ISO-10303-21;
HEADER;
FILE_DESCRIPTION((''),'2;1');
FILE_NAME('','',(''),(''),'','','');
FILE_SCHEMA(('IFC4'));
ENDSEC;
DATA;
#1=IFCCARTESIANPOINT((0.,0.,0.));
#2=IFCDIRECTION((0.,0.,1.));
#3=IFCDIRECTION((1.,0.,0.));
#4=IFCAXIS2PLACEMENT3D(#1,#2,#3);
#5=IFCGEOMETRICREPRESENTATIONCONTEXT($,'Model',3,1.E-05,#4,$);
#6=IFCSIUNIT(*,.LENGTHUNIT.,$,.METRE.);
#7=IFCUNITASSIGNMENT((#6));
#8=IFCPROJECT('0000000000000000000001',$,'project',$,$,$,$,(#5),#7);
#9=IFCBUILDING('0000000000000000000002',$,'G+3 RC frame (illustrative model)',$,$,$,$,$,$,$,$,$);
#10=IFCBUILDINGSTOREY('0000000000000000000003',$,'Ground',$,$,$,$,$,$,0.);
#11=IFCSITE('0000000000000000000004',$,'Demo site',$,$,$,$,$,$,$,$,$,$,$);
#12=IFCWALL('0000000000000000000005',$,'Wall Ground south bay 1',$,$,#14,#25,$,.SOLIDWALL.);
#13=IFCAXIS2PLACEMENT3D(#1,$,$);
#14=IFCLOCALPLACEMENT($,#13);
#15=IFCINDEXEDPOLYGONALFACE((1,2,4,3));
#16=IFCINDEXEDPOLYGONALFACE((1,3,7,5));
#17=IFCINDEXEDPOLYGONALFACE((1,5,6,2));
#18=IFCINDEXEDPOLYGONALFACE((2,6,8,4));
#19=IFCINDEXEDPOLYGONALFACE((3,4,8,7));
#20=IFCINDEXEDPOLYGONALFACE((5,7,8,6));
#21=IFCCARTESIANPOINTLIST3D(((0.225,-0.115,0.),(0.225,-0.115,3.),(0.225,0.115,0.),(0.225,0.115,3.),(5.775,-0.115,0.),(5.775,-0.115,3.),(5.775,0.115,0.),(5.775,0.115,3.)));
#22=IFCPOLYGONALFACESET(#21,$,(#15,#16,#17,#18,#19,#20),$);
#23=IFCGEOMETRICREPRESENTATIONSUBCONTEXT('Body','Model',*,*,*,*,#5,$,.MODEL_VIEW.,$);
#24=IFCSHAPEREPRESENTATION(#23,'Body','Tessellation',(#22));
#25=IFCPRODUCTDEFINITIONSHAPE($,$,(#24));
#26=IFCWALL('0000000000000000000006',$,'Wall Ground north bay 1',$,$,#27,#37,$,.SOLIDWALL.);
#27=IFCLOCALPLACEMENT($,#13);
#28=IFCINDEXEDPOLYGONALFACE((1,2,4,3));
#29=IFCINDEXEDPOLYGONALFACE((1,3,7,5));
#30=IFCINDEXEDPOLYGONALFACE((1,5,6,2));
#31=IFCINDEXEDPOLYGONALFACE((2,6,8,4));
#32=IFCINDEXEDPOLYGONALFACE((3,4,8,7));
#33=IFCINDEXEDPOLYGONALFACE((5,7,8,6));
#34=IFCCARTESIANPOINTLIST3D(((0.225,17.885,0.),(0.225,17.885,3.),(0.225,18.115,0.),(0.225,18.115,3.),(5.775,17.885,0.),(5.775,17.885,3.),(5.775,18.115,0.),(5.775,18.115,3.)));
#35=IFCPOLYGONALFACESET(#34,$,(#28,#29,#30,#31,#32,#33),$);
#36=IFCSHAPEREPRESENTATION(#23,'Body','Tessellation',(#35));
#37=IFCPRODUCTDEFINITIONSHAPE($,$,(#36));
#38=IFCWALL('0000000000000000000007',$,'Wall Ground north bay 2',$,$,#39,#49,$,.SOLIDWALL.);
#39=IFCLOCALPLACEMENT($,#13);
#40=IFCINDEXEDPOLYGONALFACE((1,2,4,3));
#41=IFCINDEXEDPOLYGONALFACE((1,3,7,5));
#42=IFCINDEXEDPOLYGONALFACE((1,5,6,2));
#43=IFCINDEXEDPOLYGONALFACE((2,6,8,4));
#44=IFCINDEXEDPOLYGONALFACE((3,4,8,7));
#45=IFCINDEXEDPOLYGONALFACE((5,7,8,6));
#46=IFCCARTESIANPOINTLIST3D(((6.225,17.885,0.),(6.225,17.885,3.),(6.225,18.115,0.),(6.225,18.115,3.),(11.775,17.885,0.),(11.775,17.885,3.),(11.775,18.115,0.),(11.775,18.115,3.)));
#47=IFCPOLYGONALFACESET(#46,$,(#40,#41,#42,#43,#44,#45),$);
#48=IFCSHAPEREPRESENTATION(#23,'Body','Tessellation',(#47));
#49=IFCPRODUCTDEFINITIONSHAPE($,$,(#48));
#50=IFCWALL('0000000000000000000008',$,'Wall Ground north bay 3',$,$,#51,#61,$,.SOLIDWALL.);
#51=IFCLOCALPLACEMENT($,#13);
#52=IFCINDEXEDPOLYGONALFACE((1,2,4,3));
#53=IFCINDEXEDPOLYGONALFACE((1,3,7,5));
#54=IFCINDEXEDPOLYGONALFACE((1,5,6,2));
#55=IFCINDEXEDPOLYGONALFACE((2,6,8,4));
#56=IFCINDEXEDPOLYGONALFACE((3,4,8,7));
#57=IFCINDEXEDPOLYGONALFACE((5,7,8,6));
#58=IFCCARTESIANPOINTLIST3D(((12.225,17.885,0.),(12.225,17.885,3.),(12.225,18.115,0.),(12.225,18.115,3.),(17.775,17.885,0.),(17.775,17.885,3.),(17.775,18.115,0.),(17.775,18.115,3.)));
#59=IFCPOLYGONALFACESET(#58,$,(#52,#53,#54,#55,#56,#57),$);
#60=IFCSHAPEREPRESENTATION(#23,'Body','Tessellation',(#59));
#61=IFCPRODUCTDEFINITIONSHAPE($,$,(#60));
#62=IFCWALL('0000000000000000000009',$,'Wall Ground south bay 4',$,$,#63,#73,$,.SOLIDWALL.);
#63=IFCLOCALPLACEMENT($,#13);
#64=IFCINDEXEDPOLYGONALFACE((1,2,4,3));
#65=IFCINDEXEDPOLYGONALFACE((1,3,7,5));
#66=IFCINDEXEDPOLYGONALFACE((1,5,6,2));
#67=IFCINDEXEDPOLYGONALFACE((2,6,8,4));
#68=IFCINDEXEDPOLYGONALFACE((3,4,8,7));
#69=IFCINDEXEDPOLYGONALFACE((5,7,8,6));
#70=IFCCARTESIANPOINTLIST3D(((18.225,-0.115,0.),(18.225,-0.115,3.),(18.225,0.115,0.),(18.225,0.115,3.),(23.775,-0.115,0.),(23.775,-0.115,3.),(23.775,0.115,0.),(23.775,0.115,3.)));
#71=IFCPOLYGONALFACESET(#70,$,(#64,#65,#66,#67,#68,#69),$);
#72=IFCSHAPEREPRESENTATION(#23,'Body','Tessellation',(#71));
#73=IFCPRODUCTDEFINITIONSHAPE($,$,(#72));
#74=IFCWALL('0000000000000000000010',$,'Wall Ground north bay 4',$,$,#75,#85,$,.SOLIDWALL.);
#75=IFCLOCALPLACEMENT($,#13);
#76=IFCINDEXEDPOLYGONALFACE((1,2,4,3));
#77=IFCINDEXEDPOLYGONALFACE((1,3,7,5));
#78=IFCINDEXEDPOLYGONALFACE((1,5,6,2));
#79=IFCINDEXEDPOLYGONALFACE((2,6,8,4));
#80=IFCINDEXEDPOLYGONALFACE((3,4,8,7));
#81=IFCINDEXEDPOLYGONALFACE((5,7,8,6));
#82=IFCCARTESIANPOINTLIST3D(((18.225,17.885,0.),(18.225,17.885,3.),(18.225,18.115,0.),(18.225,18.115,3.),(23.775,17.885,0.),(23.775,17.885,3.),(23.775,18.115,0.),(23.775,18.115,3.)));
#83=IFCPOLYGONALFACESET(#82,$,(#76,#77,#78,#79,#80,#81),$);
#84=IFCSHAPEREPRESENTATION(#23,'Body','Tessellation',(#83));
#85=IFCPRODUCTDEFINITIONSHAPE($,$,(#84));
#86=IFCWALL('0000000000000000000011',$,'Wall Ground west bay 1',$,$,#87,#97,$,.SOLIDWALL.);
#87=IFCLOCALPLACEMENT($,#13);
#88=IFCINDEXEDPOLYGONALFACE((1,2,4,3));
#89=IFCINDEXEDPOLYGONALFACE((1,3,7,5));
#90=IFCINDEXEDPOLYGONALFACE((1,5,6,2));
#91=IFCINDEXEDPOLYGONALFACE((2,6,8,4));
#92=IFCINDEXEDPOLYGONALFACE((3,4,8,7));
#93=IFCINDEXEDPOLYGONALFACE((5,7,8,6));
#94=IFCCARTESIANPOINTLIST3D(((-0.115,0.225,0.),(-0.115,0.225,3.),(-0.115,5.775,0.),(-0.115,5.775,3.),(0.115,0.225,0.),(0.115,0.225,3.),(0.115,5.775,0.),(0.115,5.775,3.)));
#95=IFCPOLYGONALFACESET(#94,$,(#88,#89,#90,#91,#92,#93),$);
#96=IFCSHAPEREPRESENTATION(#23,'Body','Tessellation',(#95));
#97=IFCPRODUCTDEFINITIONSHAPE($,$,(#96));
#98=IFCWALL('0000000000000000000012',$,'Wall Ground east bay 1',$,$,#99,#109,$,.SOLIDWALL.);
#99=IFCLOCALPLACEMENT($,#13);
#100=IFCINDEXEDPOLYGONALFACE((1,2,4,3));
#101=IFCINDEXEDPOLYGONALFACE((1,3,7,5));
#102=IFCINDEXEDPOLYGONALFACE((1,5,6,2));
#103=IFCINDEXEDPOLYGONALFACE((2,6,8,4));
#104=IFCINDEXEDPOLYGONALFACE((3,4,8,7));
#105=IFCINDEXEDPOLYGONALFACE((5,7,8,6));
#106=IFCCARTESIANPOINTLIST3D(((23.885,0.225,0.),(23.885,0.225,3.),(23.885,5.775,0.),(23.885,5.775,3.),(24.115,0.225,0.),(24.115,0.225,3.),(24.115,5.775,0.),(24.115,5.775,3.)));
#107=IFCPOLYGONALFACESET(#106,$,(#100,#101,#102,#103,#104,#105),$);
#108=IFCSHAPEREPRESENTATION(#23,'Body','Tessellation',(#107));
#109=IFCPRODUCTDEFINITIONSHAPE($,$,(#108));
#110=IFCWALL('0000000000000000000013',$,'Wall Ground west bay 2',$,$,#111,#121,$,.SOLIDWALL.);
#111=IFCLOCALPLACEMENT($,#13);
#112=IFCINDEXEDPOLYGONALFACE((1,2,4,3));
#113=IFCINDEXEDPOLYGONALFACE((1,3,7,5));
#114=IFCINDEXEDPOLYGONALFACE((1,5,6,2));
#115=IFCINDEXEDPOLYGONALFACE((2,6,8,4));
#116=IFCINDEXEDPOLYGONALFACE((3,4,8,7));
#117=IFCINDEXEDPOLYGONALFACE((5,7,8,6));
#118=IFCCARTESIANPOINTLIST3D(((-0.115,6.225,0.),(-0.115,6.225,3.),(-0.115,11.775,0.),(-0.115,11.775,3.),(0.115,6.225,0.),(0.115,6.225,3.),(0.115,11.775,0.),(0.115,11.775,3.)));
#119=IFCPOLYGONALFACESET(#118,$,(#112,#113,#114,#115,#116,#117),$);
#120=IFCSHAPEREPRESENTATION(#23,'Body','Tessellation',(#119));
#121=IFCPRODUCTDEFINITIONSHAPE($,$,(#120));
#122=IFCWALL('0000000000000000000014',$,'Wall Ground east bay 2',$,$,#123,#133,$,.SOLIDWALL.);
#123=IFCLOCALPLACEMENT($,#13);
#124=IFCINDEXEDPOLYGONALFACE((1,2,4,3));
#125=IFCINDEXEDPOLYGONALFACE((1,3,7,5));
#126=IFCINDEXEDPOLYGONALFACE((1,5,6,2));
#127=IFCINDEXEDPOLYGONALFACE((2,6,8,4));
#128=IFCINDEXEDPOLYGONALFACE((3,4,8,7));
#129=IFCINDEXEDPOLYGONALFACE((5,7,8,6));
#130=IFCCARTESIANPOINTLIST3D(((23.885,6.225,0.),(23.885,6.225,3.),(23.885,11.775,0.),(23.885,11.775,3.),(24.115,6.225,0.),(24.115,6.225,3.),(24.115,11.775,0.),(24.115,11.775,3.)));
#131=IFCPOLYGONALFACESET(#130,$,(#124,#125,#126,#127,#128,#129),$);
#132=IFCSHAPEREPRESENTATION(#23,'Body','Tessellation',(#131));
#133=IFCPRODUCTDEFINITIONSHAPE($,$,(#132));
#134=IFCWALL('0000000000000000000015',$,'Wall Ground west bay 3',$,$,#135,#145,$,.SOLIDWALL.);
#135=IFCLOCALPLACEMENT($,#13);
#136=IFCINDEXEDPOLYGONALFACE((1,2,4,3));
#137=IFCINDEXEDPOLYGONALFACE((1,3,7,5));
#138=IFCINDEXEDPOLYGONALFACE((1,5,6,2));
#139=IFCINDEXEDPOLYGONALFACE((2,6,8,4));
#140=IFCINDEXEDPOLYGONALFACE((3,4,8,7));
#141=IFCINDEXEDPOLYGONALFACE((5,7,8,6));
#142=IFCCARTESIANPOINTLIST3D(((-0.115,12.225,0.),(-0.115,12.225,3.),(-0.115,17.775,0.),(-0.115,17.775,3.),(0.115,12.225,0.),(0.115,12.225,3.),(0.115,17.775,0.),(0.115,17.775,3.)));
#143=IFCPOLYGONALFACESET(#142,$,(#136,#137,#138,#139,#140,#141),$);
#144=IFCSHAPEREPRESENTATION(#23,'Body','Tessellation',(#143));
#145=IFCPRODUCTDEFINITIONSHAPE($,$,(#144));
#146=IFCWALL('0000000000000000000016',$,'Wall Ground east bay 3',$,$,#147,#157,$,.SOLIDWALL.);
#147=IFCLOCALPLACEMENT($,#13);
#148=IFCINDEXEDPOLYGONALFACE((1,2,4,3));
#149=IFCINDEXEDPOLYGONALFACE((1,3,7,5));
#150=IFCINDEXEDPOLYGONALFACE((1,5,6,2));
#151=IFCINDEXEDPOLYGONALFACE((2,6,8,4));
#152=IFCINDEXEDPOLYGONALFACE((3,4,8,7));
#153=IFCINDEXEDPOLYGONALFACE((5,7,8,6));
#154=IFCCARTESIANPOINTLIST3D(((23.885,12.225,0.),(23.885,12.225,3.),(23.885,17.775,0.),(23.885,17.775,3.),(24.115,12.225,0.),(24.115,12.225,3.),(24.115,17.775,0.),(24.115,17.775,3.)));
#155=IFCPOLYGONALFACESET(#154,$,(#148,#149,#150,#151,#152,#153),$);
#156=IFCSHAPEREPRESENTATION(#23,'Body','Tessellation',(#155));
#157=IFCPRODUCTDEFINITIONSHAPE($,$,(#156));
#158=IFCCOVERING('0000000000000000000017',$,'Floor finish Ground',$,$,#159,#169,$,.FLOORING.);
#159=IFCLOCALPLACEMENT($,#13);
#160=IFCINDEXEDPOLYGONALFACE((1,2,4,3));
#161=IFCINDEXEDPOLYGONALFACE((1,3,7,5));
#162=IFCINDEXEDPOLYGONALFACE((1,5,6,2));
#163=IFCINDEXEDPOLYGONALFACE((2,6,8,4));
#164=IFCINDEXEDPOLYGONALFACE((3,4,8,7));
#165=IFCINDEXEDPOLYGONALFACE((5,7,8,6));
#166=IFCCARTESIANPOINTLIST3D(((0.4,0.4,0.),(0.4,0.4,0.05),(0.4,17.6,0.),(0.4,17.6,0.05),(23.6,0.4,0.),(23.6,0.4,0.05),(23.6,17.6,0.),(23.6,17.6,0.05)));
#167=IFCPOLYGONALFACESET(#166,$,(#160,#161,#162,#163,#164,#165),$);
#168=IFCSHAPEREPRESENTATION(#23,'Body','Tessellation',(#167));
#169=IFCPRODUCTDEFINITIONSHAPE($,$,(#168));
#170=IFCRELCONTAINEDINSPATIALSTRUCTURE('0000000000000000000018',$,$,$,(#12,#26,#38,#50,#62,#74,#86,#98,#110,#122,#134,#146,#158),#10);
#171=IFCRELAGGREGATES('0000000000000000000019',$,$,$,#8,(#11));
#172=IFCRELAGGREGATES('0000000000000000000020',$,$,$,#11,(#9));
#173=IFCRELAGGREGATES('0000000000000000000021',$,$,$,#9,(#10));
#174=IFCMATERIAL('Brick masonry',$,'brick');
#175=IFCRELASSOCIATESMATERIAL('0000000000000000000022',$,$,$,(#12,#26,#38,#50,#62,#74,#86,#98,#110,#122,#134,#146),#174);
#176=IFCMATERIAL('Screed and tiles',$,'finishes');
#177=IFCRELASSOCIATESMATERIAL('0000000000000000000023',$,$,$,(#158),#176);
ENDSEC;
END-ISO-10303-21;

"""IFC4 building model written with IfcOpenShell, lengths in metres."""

from ifc_helpers import new_model, si_unit, frame, frame_2d, origin, origin_with_axes, place, context, subcontext, project, spatial, rectangle, extrude, material, element, save


model = new_model("IFC4")

# Units and contexts
model_context = context("Model", 3, precision=1e-05, world=origin_with_axes())
body_context = subcontext(model_context, "Body", "Model", "MODEL_VIEW")
ifc_project = project(units=[si_unit("LENGTHUNIT", "METRE")], contexts=[model_context])

# Site, building, storey
site = spatial("IfcSite", under=ifc_project, Name="Demo site")
building = spatial("IfcBuilding", under=site, Name="G+3 RC frame (illustrative model)")
storey = spatial("IfcBuildingStorey", under=building, Name="Ground", Elevation=0.0)

# Walls
ifc_material_1 = material(Name="Brick masonry", Category="brick")
for number, where, z_axis, x_axis, name in (
    (1, (0.225, -0.115, 0.0), (0.0, 0.0, 1.0), (1.0, 0.0, 0.0), "Wall Ground south bay 1"),
    (2, (0.225, 17.885, 0.0), (0.0, 0.0, 1.0), (1.0, 0.0, 0.0), "Wall Ground north bay 1"),
    (3, (6.225, 17.885, 0.0), (0.0, 0.0, 1.0), (1.0, 0.0, 0.0), "Wall Ground north bay 2"),
    (4, (12.225, 17.885, 0.0), (0.0, 0.0, 1.0), (1.0, 0.0, 0.0), "Wall Ground north bay 3"),
    (5, (18.225, -0.115, 0.0), (0.0, 0.0, 1.0), (1.0, 0.0, 0.0), "Wall Ground south bay 4"),
    (6, (18.225, 17.885, 0.0), (0.0, 0.0, 1.0), (1.0, 0.0, 0.0), "Wall Ground north bay 4"),
):
    element("IfcWall", number, at=place(None, frame(where, z_axis=z_axis, x_axis=x_axis)), inside=storey, material=ifc_material_1, Name=name, PredefinedType="SOLIDWALL", context=body_context, shape_type="SweptSolid", body=[
        extrude(rectangle(XDim=5.55, YDim=0.23, at=frame_2d((2.775, 0.115))), origin(), (0.0, 0.0, 1.0), 3.0),
    ])
for number, where, z_axis, x_axis, name in (
    (7, (-0.115, 0.225, 0.0), (0.0, 0.0, 1.0), (1.0, 0.0, 0.0), "Wall Ground west bay 1"),
    (8, (23.885, 0.225, 0.0), (0.0, 0.0, 1.0), (1.0, 0.0, 0.0), "Wall Ground east bay 1"),
    (9, (-0.115, 6.225, 0.0), (0.0, 0.0, 1.0), (1.0, 0.0, 0.0), "Wall Ground west bay 2"),
    (10, (23.885, 6.225, 0.0), (0.0, 0.0, 1.0), (1.0, 0.0, 0.0), "Wall Ground east bay 2"),
    (11, (-0.115, 12.225, 0.0), (0.0, 0.0, 1.0), (1.0, 0.0, 0.0), "Wall Ground west bay 3"),
    (12, (23.885, 12.225, 0.0), (0.0, 0.0, 1.0), (1.0, 0.0, 0.0), "Wall Ground east bay 3"),
):
    element("IfcWall", number, at=place(None, frame(where, z_axis=z_axis, x_axis=x_axis)), inside=storey, material=ifc_material_1, Name=name, PredefinedType="SOLIDWALL", context=body_context, shape_type="SweptSolid", body=[
        extrude(rectangle(XDim=0.23, YDim=5.55, at=frame_2d((0.115, 2.775))), origin(), (0.0, 0.0, 1.0), 3.0),
    ])

# Covering
ifc_material_2 = material(Name="Screed and tiles", Category="finishes")
covering_placement = place(None, frame((0.4, 0.4, 0.0), z_axis=(0.0, 0.0, 1.0), x_axis=(1.0, 0.0, 0.0)))
element("IfcCovering", 13, at=covering_placement, inside=storey, material=ifc_material_2, Name="Floor finish Ground", PredefinedType="FLOORING", context=body_context, shape_type="SweptSolid", body=[
    extrude(rectangle(XDim=23.2, YDim=17.2, at=frame_2d((11.6, 8.6))), origin(), (0.0, 0.0, 1.0), 0.05),
])

save(model, "model.ifc")
